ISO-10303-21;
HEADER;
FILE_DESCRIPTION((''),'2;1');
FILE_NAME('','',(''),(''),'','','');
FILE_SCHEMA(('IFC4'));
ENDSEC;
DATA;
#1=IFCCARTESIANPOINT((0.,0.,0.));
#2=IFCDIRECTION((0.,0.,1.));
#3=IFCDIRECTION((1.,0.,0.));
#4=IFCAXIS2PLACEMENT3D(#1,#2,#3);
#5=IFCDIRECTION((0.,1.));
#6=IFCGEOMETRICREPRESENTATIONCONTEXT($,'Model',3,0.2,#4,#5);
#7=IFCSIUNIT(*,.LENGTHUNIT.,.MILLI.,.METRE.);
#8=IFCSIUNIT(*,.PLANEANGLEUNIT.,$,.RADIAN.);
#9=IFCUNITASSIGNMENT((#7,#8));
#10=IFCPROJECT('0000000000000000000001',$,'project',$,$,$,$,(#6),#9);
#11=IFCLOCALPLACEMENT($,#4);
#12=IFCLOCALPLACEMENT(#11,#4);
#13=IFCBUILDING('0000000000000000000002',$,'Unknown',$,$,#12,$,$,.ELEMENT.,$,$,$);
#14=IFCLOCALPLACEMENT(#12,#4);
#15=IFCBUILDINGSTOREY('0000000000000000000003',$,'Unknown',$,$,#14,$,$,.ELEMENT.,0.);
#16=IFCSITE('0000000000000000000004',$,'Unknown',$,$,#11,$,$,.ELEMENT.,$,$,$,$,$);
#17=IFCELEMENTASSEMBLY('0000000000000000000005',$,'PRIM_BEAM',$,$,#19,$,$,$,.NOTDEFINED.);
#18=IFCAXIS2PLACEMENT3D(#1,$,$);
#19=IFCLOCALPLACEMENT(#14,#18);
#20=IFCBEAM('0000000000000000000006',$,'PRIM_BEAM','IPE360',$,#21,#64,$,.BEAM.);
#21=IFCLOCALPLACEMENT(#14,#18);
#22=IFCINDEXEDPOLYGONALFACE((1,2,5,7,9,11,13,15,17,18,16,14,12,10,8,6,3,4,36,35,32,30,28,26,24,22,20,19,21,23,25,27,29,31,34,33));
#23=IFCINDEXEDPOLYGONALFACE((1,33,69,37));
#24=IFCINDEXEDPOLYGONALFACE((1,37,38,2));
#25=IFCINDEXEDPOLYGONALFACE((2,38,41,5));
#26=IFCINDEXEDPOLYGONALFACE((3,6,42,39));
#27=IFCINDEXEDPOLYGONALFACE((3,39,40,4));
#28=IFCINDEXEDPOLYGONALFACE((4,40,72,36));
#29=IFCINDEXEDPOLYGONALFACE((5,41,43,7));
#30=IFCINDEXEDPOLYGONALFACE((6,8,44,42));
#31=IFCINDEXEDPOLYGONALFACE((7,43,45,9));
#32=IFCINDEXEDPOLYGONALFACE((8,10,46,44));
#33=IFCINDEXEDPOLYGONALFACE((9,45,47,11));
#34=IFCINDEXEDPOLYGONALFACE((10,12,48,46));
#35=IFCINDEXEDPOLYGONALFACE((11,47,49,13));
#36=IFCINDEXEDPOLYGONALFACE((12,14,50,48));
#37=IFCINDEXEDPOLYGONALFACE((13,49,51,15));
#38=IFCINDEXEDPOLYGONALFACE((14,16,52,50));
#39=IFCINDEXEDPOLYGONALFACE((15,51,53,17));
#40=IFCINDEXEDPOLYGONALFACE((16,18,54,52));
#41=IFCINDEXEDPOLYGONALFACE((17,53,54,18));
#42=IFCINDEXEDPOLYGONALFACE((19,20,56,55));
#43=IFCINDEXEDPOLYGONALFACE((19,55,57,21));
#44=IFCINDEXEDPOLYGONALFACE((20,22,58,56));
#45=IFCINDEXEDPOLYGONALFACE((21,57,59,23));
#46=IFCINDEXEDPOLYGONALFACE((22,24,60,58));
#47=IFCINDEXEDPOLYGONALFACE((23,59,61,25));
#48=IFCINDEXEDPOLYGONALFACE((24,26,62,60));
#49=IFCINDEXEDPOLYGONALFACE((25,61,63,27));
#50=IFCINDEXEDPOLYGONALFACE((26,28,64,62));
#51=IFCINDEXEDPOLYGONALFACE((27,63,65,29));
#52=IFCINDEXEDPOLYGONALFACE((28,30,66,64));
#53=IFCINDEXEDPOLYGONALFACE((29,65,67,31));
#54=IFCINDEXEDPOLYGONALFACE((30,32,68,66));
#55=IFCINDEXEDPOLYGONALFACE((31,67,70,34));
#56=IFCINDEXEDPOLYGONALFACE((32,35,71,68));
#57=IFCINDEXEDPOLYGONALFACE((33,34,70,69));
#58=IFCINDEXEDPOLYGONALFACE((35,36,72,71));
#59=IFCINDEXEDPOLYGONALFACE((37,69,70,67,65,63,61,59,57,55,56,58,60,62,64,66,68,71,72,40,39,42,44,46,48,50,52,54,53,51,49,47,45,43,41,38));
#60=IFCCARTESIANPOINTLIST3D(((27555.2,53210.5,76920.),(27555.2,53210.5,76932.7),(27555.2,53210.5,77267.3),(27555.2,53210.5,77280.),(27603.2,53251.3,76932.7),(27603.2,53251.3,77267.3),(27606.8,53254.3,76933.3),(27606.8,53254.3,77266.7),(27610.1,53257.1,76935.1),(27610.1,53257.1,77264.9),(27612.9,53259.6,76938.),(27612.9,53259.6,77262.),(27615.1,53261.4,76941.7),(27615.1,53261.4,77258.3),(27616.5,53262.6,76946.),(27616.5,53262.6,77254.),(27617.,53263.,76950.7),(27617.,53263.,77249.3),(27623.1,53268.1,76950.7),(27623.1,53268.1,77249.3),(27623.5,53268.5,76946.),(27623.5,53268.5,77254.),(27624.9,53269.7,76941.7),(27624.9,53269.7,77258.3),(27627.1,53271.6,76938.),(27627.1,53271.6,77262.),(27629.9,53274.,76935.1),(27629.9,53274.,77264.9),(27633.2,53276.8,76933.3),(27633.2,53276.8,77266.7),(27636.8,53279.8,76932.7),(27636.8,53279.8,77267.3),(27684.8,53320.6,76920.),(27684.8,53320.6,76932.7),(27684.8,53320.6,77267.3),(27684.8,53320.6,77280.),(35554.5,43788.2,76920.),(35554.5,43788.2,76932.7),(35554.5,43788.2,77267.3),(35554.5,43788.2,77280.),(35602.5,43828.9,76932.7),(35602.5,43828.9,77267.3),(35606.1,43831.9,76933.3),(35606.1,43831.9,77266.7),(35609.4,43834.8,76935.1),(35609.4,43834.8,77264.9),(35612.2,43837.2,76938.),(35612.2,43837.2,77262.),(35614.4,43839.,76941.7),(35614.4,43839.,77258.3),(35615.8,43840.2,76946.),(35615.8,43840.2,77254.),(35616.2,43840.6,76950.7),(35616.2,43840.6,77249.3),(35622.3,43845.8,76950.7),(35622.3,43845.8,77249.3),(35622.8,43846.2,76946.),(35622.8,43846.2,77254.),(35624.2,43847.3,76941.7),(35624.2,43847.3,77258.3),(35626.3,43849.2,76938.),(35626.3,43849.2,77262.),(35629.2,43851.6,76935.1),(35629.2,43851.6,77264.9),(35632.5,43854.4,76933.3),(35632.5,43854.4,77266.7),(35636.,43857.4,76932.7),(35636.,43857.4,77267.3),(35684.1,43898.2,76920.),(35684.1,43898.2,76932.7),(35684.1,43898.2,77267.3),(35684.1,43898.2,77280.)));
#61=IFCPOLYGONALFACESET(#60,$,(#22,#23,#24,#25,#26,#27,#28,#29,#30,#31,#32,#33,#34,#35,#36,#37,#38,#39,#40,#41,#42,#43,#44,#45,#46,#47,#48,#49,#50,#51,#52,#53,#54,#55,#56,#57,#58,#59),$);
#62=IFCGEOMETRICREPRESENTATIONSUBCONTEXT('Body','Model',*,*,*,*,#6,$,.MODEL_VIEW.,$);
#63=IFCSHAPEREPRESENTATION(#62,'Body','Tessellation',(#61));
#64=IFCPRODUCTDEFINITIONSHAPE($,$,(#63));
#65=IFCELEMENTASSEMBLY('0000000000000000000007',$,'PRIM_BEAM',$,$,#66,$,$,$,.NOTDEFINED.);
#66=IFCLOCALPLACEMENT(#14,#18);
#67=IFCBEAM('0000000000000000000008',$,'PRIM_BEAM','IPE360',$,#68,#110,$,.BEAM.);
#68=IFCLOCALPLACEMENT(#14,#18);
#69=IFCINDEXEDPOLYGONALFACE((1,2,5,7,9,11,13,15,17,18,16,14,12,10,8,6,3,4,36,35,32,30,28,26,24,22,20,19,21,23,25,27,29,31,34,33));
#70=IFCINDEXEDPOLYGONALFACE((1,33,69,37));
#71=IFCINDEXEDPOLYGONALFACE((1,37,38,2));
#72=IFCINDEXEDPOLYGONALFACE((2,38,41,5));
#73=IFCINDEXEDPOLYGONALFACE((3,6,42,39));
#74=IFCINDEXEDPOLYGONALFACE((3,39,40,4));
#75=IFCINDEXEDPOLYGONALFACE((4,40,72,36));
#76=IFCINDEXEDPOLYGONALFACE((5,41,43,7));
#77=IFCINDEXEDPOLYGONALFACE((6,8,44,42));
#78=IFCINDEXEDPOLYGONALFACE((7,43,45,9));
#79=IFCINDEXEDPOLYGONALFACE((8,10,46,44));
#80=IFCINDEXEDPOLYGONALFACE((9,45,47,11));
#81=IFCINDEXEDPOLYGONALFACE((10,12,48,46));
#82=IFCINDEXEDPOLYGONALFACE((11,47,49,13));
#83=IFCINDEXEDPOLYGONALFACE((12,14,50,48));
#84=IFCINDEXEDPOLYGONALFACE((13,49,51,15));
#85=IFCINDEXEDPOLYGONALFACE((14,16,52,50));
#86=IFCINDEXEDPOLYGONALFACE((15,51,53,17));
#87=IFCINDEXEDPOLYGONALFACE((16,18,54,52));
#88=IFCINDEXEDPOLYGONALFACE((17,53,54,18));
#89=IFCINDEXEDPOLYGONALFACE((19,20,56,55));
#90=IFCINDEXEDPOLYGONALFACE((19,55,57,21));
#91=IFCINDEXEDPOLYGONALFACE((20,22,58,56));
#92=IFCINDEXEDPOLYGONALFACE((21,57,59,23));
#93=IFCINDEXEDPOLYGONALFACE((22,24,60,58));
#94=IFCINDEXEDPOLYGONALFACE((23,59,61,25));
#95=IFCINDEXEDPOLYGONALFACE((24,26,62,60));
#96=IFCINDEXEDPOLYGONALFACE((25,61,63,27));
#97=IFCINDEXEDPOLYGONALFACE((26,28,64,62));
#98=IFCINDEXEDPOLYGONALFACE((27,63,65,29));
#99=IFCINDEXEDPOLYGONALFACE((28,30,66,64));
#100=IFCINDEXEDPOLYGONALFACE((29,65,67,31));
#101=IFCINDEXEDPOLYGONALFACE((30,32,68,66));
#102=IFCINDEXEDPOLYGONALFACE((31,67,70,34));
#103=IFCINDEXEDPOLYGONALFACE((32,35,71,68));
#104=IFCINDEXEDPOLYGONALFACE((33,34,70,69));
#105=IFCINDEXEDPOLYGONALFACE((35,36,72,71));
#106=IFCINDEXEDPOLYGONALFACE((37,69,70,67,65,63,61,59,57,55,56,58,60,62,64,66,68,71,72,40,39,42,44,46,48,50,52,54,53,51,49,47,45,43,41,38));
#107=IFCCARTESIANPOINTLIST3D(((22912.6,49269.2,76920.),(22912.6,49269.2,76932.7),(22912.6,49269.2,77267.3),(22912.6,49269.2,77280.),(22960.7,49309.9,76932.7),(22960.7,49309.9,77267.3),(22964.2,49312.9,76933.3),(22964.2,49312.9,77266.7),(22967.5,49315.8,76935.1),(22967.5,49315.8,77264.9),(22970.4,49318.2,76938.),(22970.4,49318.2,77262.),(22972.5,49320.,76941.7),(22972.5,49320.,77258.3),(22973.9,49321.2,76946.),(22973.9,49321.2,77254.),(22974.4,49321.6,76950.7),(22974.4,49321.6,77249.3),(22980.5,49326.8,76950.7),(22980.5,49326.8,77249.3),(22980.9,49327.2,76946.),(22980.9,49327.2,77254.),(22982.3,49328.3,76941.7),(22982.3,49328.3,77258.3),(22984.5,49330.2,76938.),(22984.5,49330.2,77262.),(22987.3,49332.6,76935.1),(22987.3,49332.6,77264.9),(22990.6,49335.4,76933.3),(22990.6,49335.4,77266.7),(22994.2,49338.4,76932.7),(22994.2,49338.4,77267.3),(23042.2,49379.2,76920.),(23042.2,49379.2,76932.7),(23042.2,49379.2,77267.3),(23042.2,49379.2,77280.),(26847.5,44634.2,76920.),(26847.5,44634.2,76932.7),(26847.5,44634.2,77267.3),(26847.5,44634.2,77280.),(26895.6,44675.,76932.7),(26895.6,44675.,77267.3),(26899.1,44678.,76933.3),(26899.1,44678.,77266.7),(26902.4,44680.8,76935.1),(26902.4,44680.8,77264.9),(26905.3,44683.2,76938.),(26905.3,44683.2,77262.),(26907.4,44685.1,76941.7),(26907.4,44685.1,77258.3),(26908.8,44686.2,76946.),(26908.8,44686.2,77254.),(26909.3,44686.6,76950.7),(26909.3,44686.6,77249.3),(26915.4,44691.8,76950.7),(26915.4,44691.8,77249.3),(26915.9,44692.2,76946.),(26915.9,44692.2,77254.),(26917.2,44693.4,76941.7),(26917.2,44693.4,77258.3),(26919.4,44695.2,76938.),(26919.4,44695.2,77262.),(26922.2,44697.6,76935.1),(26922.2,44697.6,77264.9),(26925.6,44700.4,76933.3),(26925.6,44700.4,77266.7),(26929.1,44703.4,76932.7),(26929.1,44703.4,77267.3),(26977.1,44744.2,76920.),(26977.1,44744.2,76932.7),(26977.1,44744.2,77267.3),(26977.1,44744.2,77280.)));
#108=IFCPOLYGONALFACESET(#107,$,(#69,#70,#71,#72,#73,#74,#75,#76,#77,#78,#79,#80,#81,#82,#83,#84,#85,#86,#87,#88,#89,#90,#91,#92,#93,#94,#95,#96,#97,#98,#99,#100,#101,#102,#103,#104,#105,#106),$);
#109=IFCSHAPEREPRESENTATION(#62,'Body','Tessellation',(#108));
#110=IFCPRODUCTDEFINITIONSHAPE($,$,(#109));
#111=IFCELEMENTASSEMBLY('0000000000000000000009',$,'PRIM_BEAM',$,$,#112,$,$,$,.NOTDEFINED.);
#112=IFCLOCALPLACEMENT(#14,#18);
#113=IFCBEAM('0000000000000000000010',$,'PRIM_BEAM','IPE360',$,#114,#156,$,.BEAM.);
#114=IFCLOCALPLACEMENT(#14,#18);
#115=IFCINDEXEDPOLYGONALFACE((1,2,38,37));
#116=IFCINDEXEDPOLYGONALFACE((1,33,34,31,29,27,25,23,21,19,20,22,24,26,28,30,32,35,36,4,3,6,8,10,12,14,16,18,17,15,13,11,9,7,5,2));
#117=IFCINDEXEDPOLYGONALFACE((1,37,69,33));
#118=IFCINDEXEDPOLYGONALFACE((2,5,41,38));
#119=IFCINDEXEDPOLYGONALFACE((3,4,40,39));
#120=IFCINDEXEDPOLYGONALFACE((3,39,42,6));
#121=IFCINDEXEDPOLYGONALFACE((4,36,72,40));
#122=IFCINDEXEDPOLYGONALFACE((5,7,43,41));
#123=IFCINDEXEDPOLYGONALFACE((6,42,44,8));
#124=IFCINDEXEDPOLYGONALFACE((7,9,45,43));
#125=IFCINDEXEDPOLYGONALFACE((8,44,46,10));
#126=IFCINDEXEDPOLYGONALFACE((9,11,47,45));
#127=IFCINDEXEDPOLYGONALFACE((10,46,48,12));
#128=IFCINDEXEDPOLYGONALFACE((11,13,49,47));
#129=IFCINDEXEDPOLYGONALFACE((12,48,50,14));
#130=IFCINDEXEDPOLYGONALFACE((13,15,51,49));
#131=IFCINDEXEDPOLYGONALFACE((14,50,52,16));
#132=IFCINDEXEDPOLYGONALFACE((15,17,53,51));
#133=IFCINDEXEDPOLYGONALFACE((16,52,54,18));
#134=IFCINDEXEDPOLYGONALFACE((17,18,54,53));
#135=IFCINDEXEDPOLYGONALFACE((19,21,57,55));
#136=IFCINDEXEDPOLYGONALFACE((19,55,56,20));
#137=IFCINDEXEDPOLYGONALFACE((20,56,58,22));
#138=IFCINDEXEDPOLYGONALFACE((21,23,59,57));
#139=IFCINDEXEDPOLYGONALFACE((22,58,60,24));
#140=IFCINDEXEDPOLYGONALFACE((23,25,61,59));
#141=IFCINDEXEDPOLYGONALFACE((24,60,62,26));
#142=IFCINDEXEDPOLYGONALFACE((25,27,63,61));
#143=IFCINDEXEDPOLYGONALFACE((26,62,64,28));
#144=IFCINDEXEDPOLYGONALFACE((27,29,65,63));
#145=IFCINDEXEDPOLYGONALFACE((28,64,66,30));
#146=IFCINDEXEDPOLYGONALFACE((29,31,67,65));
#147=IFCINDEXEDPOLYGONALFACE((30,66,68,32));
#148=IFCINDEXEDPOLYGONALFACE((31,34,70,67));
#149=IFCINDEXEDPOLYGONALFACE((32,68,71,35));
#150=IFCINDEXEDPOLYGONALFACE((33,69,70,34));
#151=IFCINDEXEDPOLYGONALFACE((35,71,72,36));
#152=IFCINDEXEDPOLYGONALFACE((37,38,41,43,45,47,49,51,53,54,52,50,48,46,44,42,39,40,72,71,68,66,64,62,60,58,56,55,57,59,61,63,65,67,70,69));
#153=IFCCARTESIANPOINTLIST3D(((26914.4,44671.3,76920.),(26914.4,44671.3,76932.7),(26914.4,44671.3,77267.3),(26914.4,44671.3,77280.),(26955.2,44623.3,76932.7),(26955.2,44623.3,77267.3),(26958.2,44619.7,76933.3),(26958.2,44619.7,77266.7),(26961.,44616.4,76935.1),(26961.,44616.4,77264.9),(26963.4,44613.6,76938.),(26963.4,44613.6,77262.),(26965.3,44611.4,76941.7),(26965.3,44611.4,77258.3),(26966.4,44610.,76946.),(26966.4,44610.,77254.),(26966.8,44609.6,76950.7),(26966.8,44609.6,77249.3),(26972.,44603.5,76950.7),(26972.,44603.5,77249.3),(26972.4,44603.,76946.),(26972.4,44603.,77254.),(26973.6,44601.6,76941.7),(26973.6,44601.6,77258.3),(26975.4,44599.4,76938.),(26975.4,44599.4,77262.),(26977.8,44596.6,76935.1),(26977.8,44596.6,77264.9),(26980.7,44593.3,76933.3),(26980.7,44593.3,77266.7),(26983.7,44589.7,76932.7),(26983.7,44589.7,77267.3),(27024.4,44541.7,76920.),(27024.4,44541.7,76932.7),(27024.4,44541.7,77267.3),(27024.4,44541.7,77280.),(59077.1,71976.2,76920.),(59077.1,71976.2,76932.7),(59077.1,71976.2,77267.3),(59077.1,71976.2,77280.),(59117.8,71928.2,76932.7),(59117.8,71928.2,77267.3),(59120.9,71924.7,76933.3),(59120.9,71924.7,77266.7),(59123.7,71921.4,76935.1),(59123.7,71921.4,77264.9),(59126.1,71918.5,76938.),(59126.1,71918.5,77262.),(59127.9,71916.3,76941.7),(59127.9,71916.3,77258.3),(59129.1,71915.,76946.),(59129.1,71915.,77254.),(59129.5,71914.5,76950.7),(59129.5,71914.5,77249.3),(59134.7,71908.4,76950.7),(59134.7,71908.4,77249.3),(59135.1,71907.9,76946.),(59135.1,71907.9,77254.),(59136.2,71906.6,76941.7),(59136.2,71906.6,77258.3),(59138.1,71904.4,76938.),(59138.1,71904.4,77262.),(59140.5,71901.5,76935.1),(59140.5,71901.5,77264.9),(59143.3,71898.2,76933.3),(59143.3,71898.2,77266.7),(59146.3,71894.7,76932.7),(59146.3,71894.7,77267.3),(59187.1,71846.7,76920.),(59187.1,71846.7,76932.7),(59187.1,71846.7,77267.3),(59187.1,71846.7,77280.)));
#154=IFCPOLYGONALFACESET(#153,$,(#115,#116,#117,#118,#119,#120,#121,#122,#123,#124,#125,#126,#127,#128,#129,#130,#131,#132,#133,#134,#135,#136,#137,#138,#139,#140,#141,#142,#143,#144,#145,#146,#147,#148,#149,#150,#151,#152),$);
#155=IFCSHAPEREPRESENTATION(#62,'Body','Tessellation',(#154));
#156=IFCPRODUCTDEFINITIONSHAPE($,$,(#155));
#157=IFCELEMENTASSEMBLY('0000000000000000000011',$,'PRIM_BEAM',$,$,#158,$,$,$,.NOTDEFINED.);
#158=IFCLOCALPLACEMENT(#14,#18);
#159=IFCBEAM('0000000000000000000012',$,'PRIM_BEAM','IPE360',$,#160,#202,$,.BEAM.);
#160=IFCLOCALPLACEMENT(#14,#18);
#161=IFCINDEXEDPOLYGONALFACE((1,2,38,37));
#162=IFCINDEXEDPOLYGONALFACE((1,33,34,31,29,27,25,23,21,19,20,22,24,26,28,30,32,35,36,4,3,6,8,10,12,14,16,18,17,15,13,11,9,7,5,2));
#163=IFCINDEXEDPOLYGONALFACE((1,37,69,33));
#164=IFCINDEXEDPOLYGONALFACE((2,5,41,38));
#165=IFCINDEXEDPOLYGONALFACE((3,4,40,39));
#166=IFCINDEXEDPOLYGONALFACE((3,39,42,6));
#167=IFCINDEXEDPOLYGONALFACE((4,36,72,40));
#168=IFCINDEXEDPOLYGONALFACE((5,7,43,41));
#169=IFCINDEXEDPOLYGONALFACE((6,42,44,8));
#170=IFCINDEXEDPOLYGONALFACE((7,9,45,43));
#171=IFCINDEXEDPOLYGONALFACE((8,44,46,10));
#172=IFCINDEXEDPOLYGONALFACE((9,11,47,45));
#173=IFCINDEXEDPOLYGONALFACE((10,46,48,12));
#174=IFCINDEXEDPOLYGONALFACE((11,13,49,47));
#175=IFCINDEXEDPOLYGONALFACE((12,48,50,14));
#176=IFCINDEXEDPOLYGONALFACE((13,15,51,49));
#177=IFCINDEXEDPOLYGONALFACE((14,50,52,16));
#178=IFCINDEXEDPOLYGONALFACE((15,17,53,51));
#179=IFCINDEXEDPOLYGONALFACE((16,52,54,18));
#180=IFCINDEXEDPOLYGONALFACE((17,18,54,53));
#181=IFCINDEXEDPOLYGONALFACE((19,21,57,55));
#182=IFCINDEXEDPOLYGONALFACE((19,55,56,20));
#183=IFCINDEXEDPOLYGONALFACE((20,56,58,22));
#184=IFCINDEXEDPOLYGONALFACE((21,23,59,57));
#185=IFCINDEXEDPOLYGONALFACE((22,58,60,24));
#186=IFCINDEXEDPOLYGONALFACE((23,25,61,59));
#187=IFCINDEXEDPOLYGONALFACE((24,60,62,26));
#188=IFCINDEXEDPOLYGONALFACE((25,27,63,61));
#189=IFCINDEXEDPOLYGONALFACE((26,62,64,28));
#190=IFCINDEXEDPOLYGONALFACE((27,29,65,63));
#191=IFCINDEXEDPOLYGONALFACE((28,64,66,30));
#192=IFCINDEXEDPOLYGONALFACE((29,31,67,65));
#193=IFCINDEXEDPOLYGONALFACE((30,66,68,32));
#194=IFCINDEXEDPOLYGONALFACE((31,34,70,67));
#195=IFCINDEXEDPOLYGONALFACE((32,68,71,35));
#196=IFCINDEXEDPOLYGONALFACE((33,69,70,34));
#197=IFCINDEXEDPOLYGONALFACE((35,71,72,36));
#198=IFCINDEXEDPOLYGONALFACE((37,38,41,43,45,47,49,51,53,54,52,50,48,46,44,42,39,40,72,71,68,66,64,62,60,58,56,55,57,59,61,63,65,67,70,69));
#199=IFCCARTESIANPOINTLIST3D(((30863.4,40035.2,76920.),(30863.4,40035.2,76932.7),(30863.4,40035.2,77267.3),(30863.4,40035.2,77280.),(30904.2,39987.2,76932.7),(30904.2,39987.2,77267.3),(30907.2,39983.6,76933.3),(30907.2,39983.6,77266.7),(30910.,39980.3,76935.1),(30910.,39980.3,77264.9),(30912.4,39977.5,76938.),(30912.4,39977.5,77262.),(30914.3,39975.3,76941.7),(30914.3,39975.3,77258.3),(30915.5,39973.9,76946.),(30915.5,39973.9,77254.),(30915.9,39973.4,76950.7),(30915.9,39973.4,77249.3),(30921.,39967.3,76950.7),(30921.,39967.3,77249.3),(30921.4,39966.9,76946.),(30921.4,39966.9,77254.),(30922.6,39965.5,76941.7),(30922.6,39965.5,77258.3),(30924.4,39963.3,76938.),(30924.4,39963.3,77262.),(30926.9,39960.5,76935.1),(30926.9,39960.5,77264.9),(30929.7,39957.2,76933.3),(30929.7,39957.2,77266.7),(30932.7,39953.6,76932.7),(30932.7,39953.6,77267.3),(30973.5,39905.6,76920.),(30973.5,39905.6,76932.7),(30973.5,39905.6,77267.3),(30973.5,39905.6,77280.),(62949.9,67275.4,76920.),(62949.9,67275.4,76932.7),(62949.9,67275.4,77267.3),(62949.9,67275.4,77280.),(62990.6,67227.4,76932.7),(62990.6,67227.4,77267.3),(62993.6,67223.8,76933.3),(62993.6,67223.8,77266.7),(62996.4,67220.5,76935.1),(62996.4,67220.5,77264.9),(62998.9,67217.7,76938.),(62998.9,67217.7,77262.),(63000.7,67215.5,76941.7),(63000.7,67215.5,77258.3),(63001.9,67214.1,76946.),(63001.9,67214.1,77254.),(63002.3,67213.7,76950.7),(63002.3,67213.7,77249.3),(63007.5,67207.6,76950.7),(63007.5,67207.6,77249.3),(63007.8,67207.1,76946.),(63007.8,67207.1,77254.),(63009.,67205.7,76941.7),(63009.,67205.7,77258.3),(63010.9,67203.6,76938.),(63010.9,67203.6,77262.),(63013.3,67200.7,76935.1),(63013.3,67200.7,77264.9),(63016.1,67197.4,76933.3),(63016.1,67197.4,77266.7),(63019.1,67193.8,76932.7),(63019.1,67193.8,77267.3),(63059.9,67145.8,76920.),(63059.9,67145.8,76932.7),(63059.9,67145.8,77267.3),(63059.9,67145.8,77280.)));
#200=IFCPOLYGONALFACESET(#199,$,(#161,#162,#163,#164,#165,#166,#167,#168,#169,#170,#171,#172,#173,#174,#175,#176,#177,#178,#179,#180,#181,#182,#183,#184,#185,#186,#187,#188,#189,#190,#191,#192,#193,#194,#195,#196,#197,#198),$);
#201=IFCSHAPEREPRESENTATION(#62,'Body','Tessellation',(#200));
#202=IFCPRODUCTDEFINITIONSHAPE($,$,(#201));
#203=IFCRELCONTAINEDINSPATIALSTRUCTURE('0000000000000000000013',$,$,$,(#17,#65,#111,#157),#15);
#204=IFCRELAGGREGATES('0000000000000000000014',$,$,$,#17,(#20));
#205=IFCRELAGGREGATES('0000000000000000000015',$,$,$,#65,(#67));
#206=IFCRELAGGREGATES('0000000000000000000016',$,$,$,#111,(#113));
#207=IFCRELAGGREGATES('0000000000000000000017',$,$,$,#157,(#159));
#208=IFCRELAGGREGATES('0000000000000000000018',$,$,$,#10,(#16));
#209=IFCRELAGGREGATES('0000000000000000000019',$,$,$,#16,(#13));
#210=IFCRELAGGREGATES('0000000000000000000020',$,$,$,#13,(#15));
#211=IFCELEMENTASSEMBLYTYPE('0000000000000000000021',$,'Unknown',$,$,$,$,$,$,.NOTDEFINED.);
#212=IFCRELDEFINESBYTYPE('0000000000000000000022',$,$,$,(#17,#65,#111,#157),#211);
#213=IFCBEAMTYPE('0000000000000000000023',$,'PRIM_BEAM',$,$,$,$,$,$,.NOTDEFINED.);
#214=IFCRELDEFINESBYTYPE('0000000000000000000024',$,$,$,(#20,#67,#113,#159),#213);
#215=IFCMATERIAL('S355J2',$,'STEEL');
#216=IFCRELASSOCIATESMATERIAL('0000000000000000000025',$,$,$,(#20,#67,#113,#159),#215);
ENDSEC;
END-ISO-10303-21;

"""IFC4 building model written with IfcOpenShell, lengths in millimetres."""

from ifc_helpers import new_model, si_unit, direction, frame, origin_with_axes, origin_2d_with_axis, place, context, subcontext, project, spatial, i_section, extrude, material, material_profile, profile_set, profile_usage, type_object, element, aggregate, save


model = new_model("IFC4")

# Units and contexts
model_context = context("Model", 3, precision=0.2, world=origin_with_axes(), true_north=direction((0.0, 1.0)))
body_context = subcontext(model_context, "Body", "Model", "MODEL_VIEW")
ifc_project = project(units=[si_unit("LENGTHUNIT", "METRE", prefix="MILLI"), si_unit("PLANEANGLEUNIT", "RADIAN")], contexts=[model_context])

# Site, building, storey
site_placement = place(None, origin_with_axes())
site = spatial("IfcSite", under=ifc_project, at=site_placement, Name="Unknown", CompositionType="ELEMENT")
building_placement = place(site_placement, origin_with_axes())
building = spatial("IfcBuilding", under=site, at=building_placement, Name="Unknown", CompositionType="ELEMENT")
storey_placement = place(building_placement, origin_with_axes())
storey = spatial("IfcBuildingStorey", under=building, at=storey_placement, Name="Unknown", CompositionType="ELEMENT", Elevation=0.0)

# Shared definitions
element_assembly_type = type_object("IfcElementAssemblyType", Name="Unknown", PredefinedType="NOTDEFINED")
ifc_material_1 = material(Name="S355J2", Category="STEEL")

# Element assemblies, beams
ifc_material_profile_1 = material_profile(ifc_material_1, i_section(OverallWidth=170.0, OverallDepth=360.0, WebThickness=8.0, FlangeThickness=12.7, FilletRadius=18.0, FlangeEdgeRadius=0.0, FlangeSlope=0.0, at=origin_2d_with_axis()), Name="IPE360")
ifc_profile_set_1 = profile_set([ifc_material_profile_1])
ifc_profile_usage_1 = profile_usage(ifc_profile_set_1, cardinal=2)
beam_type_1 = type_object("IfcBeamType", Name="PRIM_BEAM")
assembly_1_placement = place(storey_placement, frame((35619.3, 43843.2, 77100.0), z_axis=(0.762329, 0.64719, 0.0), x_axis=(-0.64719, 0.762329, 0.0)))
assembly_1 = element("IfcElementAssembly", 1, at=assembly_1_placement, inside=storey, type_object=element_assembly_type, Name="PRIM_BEAM", PredefinedType="NOTDEFINED")
beam_1_placement = place(assembly_1_placement, origin_with_axes())
beam_1 = element("IfcBeam", 2, at=beam_1_placement, type_object=beam_type_1, material=ifc_profile_usage_1, Name="PRIM_BEAM", Description="IPE360", PredefinedType="BEAM", context=body_context, shape_type="SolidModel", body=[
    extrude(i_section(OverallWidth=170.0, OverallDepth=360.0, WebThickness=8.0, FlangeThickness=12.7, FilletRadius=18.0, FlangeEdgeRadius=0.0, FlangeSlope=0.0, at=origin_2d_with_axis()), frame((0.0, 0.0, 0.0), z_axis=(-1.0, 0.0, 0.0), x_axis=(0.0, 0.0, 1.0)), (0.0, 0.0, -1.0), 12360.0),
])
aggregate(assembly_1, [beam_1])
assembly_2_placement = place(storey_placement, frame((26912.3, 44689.2, 77100.0), z_axis=(0.762329, 0.64719, 0.0), x_axis=(-0.64719, 0.762329, 0.0)))
assembly_2 = element("IfcElementAssembly", 3, at=assembly_2_placement, inside=storey, type_object=element_assembly_type, Name="PRIM_BEAM", PredefinedType="NOTDEFINED")
beam_2_placement = place(assembly_2_placement, origin_with_axes())
beam_2 = element("IfcBeam", 4, at=beam_2_placement, type_object=beam_type_1, material=ifc_profile_usage_1, Name="PRIM_BEAM", Description="IPE360", PredefinedType="BEAM", context=body_context, shape_type="SolidModel", body=[
    extrude(i_section(OverallWidth=170.0, OverallDepth=360.0, WebThickness=8.0, FlangeThickness=12.7, FilletRadius=18.0, FlangeEdgeRadius=0.0, FlangeSlope=0.0, at=origin_2d_with_axis()), frame((0.0, 0.0, 0.0), z_axis=(-1.0, 0.0, 0.0), x_axis=(0.0, 0.0, 1.0)), (0.0, 0.0, -1.0), 6080.0),
])
aggregate(assembly_2, [beam_2])
assembly_3_placement = place(storey_placement, frame((26969.4, 44606.5, 77100.0), z_axis=(0.64719, -0.762329, 0.0), x_axis=(0.762329, 0.64719, 0.0)))
assembly_3 = element("IfcElementAssembly", 5, at=assembly_3_placement, inside=storey, type_object=element_assembly_type, Name="PRIM_BEAM", PredefinedType="NOTDEFINED")
beam_3_placement = place(assembly_3_placement, origin_with_axes())
beam_3 = element("IfcBeam", 6, at=beam_3_placement, type_object=beam_type_1, material=ifc_profile_usage_1, Name="PRIM_BEAM", Description="IPE360", PredefinedType="BEAM", context=body_context, shape_type="SolidModel", body=[
    extrude(i_section(OverallWidth=170.0, OverallDepth=360.0, WebThickness=8.0, FlangeThickness=12.7, FilletRadius=18.0, FlangeEdgeRadius=0.0, FlangeSlope=0.0, at=origin_2d_with_axis()), frame((0.0, 0.0, 0.0), z_axis=(-1.0, 0.0, 0.0), x_axis=(0.0, 0.0, 1.0)), (0.0, 0.0, -1.0), 42190.0),
])
aggregate(assembly_3, [beam_3])
assembly_4_placement = place(storey_placement, frame((30918.4, 39970.4, 77100.0), z_axis=(0.64719, -0.762329, 0.0), x_axis=(0.762329, 0.64719, 0.0)))
assembly_4 = element("IfcElementAssembly", 7, at=assembly_4_placement, inside=storey, type_object=element_assembly_type, Name="PRIM_BEAM", PredefinedType="NOTDEFINED")
beam_4_placement = place(assembly_4_placement, origin_with_axes())
beam_4 = element("IfcBeam", 8, at=beam_4_placement, type_object=beam_type_1, material=ifc_profile_usage_1, Name="PRIM_BEAM", Description="IPE360", PredefinedType="BEAM", context=body_context, shape_type="SolidModel", body=[
    extrude(i_section(OverallWidth=170.0, OverallDepth=360.0, WebThickness=8.0, FlangeThickness=12.7, FilletRadius=18.0, FlangeEdgeRadius=0.0, FlangeSlope=0.0, at=origin_2d_with_axis()), frame((0.0, 0.0, 0.0), z_axis=(-1.0, 0.0, 0.0), x_axis=(0.0, 0.0, 1.0)), (0.0, 0.0, -1.0), 42090.0),
])
aggregate(assembly_4, [beam_4])

save(model, "model.ifc")
